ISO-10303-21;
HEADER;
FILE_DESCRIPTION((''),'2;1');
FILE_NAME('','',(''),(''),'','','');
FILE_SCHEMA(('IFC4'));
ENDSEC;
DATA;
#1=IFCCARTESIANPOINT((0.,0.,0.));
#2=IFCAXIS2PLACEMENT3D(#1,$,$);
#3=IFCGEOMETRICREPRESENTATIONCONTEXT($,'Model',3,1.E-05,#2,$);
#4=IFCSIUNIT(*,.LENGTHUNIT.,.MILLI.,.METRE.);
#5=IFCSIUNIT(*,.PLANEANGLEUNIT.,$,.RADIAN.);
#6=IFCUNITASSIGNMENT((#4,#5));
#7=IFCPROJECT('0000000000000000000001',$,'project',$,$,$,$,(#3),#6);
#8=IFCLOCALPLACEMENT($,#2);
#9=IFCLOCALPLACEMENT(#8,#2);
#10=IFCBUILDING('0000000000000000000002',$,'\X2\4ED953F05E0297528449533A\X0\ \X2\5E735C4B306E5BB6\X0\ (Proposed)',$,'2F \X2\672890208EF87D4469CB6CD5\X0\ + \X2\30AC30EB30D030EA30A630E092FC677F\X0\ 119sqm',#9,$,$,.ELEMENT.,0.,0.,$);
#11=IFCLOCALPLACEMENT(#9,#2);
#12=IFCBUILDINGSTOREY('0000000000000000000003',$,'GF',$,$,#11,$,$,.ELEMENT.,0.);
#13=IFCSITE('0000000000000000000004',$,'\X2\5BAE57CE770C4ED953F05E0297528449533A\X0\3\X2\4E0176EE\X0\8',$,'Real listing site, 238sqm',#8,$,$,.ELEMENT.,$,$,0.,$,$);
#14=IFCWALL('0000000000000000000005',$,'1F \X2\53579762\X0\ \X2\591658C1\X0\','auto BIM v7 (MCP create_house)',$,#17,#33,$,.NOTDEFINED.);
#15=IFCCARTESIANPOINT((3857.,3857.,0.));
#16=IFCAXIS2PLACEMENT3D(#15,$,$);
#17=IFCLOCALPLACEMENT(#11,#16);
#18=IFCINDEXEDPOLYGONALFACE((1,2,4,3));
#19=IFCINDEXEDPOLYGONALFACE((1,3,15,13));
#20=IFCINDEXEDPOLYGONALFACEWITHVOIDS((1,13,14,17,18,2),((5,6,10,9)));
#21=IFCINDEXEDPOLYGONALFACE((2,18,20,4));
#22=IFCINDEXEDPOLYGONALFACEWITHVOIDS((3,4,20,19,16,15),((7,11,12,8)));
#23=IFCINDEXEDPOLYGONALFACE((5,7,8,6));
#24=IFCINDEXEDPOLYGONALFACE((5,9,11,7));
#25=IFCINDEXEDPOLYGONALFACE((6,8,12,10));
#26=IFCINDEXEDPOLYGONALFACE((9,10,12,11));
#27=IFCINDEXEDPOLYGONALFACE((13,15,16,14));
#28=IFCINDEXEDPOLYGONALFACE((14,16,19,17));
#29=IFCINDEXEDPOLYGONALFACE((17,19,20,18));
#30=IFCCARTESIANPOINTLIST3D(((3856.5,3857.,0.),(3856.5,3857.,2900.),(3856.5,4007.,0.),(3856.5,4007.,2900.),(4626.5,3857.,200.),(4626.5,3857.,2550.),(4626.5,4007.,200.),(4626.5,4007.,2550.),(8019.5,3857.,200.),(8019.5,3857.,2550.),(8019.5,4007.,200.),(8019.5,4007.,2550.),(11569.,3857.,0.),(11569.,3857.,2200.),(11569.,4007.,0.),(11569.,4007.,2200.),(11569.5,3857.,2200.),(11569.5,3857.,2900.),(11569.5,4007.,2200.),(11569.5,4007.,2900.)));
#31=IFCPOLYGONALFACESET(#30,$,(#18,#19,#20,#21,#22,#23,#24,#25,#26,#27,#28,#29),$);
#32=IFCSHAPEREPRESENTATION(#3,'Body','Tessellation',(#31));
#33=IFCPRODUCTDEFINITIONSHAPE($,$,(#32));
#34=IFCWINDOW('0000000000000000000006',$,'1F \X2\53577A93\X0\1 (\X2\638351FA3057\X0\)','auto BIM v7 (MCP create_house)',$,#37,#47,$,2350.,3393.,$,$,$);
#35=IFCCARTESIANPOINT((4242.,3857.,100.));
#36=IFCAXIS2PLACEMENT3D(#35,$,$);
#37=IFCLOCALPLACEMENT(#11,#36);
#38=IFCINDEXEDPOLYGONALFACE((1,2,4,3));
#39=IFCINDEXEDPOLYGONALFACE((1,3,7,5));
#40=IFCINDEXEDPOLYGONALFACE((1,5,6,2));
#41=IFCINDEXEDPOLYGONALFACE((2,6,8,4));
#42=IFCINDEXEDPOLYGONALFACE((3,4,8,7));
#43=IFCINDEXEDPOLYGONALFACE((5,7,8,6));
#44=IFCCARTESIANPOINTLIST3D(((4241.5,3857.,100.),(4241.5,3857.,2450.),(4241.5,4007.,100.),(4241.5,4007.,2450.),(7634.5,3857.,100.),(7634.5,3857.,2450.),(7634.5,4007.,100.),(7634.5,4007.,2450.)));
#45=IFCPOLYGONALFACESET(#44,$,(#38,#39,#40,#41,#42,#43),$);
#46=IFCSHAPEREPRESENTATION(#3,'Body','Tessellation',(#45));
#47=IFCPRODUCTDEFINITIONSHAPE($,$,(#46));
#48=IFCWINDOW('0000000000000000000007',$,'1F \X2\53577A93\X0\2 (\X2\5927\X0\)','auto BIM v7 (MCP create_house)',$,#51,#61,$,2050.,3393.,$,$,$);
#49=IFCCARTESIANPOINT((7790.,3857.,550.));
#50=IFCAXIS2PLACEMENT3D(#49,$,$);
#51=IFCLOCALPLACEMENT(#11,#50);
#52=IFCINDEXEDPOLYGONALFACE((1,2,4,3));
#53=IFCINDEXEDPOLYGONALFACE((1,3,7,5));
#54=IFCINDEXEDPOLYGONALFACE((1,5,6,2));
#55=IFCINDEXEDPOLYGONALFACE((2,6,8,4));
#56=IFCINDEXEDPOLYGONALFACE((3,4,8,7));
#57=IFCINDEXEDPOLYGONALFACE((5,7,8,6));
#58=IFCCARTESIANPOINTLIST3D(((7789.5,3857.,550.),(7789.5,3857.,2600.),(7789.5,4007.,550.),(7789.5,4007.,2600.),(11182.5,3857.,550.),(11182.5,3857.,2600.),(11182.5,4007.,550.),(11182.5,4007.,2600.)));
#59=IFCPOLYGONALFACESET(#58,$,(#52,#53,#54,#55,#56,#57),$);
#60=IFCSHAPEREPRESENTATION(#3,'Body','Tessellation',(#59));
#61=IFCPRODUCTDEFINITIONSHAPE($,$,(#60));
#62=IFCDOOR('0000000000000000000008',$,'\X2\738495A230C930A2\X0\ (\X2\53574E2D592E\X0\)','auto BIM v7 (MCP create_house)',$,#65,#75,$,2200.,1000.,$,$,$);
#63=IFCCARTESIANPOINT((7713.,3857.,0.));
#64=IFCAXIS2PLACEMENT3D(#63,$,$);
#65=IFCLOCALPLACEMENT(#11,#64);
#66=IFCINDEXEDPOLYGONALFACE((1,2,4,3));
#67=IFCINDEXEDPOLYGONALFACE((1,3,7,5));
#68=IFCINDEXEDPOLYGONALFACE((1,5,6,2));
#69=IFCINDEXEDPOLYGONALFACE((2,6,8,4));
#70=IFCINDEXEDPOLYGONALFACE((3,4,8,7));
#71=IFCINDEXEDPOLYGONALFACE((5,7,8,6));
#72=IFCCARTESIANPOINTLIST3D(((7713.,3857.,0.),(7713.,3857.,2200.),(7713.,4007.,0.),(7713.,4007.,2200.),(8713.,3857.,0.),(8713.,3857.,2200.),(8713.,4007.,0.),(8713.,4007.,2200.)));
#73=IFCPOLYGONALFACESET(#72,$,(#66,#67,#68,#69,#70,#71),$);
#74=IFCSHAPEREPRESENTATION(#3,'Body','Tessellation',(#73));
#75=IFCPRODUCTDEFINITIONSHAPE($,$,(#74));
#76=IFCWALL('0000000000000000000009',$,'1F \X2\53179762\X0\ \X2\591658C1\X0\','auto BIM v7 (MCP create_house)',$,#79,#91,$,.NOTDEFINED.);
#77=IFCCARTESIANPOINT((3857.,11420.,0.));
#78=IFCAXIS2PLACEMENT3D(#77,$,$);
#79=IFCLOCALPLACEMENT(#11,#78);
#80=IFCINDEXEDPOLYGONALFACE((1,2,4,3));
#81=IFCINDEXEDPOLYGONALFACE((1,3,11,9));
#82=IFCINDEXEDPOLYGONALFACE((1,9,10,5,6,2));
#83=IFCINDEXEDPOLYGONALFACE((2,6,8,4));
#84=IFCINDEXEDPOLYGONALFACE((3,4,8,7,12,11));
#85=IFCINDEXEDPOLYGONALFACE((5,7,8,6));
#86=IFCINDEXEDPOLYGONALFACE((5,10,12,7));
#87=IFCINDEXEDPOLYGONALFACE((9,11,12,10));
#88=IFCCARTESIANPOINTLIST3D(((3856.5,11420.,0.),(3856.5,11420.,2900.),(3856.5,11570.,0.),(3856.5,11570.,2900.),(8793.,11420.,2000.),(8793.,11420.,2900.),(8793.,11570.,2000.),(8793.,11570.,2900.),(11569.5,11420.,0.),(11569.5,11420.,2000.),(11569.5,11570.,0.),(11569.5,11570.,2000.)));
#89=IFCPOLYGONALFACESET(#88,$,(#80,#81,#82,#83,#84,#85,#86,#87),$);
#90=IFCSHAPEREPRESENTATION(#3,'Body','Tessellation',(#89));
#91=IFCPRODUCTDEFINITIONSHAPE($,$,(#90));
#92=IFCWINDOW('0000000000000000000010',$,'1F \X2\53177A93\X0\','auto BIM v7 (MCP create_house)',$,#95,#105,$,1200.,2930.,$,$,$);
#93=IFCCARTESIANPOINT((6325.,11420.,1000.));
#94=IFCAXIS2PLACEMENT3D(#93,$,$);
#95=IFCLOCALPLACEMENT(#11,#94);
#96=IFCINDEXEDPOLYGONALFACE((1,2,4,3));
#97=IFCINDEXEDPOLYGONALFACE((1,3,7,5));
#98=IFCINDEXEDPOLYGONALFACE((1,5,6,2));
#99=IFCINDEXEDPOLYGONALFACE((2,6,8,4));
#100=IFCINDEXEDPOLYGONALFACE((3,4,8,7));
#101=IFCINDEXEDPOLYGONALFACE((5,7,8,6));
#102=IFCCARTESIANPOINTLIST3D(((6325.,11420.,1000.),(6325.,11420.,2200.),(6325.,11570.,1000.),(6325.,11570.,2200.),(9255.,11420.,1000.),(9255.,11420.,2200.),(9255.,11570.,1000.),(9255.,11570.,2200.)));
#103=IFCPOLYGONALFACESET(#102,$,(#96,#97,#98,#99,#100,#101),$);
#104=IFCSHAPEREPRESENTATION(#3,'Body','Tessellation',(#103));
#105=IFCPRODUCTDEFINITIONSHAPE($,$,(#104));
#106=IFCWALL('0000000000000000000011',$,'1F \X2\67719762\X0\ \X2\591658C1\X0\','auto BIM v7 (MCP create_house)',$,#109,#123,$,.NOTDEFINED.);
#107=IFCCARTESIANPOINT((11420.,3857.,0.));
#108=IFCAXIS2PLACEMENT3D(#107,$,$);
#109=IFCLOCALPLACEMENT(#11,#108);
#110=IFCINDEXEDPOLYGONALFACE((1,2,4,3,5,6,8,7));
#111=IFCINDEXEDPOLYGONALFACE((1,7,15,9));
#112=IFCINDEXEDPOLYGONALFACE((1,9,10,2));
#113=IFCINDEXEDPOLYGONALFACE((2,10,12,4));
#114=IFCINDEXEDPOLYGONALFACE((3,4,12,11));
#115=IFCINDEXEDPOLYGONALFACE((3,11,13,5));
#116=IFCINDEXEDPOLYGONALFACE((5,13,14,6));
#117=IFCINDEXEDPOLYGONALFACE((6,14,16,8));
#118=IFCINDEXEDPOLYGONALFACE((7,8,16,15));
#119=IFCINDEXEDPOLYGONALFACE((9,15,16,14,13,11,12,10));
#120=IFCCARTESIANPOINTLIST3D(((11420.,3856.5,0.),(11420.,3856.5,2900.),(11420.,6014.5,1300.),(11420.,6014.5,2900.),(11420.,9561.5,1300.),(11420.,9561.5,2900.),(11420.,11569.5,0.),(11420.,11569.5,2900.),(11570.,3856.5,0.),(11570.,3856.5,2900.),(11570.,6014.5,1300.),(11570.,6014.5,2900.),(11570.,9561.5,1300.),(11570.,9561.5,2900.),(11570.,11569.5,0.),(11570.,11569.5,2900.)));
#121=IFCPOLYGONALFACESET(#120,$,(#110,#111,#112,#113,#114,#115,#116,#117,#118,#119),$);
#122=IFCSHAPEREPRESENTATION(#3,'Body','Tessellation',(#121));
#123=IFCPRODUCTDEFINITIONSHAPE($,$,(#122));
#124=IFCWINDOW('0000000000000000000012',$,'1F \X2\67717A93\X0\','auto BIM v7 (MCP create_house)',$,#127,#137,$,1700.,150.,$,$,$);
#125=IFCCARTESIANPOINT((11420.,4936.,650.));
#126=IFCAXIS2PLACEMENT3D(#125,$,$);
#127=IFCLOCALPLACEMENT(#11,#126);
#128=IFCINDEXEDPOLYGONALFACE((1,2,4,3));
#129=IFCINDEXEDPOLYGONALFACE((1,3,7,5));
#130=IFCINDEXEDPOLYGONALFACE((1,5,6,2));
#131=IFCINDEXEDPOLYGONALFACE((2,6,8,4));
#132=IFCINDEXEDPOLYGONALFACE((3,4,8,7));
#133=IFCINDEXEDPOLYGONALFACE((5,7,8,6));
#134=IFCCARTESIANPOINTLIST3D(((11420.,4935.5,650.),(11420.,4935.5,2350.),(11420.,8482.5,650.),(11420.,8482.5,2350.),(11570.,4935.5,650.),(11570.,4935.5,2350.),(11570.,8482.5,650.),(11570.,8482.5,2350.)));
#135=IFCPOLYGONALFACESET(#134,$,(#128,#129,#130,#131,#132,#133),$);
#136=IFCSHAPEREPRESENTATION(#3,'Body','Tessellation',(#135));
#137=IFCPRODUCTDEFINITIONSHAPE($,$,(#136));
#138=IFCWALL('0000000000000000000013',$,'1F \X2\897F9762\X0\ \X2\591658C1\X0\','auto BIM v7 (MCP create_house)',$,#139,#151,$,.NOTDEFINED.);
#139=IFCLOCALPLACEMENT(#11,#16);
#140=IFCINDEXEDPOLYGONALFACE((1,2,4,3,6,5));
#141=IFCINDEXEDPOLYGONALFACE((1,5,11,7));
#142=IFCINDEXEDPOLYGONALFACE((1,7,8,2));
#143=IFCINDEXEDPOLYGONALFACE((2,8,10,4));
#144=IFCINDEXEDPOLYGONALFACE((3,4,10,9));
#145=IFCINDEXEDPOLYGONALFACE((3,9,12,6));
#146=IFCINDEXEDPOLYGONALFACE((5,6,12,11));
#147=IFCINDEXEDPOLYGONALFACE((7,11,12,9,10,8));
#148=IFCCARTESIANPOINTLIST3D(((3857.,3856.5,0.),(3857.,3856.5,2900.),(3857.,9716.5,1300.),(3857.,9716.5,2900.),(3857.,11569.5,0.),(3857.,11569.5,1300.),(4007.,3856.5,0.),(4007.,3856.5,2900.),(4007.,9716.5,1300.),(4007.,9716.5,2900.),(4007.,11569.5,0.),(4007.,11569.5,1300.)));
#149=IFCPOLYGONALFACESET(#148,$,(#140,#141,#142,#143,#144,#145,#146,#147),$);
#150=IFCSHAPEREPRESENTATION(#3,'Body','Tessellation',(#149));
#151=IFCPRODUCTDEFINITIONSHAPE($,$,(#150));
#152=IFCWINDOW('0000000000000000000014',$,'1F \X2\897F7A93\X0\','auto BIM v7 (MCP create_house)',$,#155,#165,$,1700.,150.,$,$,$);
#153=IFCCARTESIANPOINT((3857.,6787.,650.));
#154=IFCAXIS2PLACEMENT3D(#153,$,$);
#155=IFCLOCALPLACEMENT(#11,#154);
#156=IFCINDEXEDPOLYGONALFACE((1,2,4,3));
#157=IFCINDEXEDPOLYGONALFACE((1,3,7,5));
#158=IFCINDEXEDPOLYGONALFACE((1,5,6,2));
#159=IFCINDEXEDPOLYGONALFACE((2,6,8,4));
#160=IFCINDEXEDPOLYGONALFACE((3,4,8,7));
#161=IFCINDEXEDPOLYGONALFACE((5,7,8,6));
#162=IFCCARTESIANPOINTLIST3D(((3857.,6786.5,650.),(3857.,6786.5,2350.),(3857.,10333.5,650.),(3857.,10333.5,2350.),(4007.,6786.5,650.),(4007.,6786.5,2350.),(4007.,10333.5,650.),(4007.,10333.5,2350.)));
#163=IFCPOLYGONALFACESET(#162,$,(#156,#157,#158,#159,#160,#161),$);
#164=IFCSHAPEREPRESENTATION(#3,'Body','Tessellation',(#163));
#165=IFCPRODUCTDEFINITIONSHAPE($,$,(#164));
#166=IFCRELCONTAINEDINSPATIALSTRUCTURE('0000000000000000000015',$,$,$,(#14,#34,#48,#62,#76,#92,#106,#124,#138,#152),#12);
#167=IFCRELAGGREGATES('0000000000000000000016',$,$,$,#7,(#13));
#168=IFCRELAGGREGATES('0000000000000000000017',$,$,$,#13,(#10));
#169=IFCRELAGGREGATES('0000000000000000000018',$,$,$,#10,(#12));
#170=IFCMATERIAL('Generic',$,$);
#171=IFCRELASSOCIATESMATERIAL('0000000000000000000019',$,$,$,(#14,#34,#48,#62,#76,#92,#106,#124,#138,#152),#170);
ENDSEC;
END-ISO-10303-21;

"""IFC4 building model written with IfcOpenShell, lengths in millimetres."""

from ifc_helpers import new_model, si_unit, frame, frame_2d, origin, place, context, project, spatial, rectangle, extrude, material, element, fill, save


model = new_model("IFC4")

# Units and contexts
model_context = context("Model", 3, precision=1e-05, world=origin())
ifc_project = project(units=[si_unit("LENGTHUNIT", "METRE", prefix="MILLI"), si_unit("PLANEANGLEUNIT", "RADIAN")], contexts=[model_context])

# Site, building, storey
site_placement = place(None, origin())
site = spatial("IfcSite", under=ifc_project, at=site_placement, Name="宮城県仙台市青葉区3丁目8", ObjectType="Real listing site, 238sqm", CompositionType="ELEMENT", RefElevation=0.0)
building_placement = place(site_placement, origin())
building = spatial("IfcBuilding", under=site, at=building_placement, Name="仙台市青葉区 平屋の家 (Proposed)", ObjectType="2F 木造軸組構法 + ガルバリウム鋼板 119sqm", CompositionType="ELEMENT", ElevationOfRefHeight=0.0, ElevationOfTerrain=0.0)
storey_placement = place(building_placement, origin())
storey = spatial("IfcBuildingStorey", under=building, at=storey_placement, Name="GF", CompositionType="ELEMENT", Elevation=0.0)

# Shared definitions
ifc_material = material(Name="Generic")

# Wall, openings, windows, door
wall_1_placement = place(storey_placement, frame((3857.0, 3857.0, 0.0)))
wall_1 = element("IfcWall", 1, at=wall_1_placement, inside=storey, material=ifc_material, Name="1F 南面 外壁", Description="auto BIM v7 (MCP create_house)", PredefinedType="NOTDEFINED", context=model_context, shape_type="SweptSolid", body=[
    extrude(rectangle(XDim=7713.0, YDim=150.0, at=frame_2d((3856.0, 75.0))), frame((3857.0, 3857.0, 0.0)), (0.0, 0.0, 1.0), 2900.0),
])
opening_1_placement = place(storey_placement, frame((4242.0, 3857.0, 100.0)))
opening_1 = element("IfcOpeningElement", 2, at=opening_1_placement, cuts=wall_1, PredefinedType="NOTDEFINED", context=model_context, shape_type="SweptSolid", body=[
    extrude(rectangle(XDim=3393.0, YDim=150.0, at=frame_2d((1696.0, 75.0))), frame((4242.0, 3857.0, 100.0)), (0.0, 0.0, 1.0), 2350.0),
])
opening_2_placement = place(storey_placement, frame((7790.0, 3857.0, 550.0)))
opening_2 = element("IfcOpeningElement", 3, at=opening_2_placement, cuts=wall_1, PredefinedType="NOTDEFINED", context=model_context, shape_type="SweptSolid", body=[
    extrude(rectangle(XDim=3393.0, YDim=150.0, at=frame_2d((1696.0, 75.0))), frame((7790.0, 3857.0, 550.0)), (0.0, 0.0, 1.0), 2050.0),
])
opening_3_placement = place(storey_placement, frame((7713.0, 3857.0, 0.0)))
opening_3 = element("IfcOpeningElement", 4, at=opening_3_placement, cuts=wall_1, PredefinedType="NOTDEFINED", context=model_context, shape_type="SweptSolid", body=[
    extrude(rectangle(XDim=1000.0, YDim=150.0, at=frame_2d((500.0, 75.0))), frame((7713.0, 3857.0, 0.0)), (0.0, 0.0, 1.0), 2200.0),
])
window_1_placement = place(storey_placement, frame((4242.0, 3857.0, 100.0)))
window_1 = element("IfcWindow", 5, at=window_1_placement, inside=storey, material=ifc_material, Name="1F 南窓1 (掃出し)", Description="auto BIM v7 (MCP create_house)", OverallHeight=2350.0, OverallWidth=3393.0, context=model_context, shape_type="SweptSolid", body=[
    extrude(rectangle(XDim=3393.0, YDim=150.0, at=frame_2d((1696.0, 75.0))), frame((4242.0, 3857.0, 100.0)), (0.0, 0.0, 1.0), 2350.0),
])
fill(opening_1, window_1)
window_2_placement = place(storey_placement, frame((7790.0, 3857.0, 550.0)))
window_2 = element("IfcWindow", 6, at=window_2_placement, inside=storey, material=ifc_material, Name="1F 南窓2 (大)", Description="auto BIM v7 (MCP create_house)", OverallHeight=2050.0, OverallWidth=3393.0, context=model_context, shape_type="SweptSolid", body=[
    extrude(rectangle(XDim=3393.0, YDim=150.0, at=frame_2d((1696.0, 75.0))), frame((7790.0, 3857.0, 550.0)), (0.0, 0.0, 1.0), 2050.0),
])
fill(opening_2, window_2)
door_placement = place(storey_placement, frame((7713.0, 3857.0, 0.0)))
door = element("IfcDoor", 7, at=door_placement, inside=storey, material=ifc_material, Name="玄関ドア (南中央)", Description="auto BIM v7 (MCP create_house)", OverallHeight=2200.0, OverallWidth=1000.0, context=model_context, shape_type="SweptSolid", body=[
    extrude(rectangle(XDim=1000.0, YDim=150.0, at=frame_2d((500.0, 75.0))), frame((7713.0, 3857.0, 0.0)), (0.0, 0.0, 1.0), 2200.0),
])
fill(opening_3, door)

# Walls, openings, windows
wall_2_placement = place(storey_placement, frame((3857.0, 11420.0, 0.0)))
wall_2 = element("IfcWall", 8, at=wall_2_placement, inside=storey, material=ifc_material, Name="1F 北面 外壁", Description="auto BIM v7 (MCP create_house)", PredefinedType="NOTDEFINED", context=model_context, shape_type="SweptSolid", body=[
    extrude(rectangle(XDim=7713.0, YDim=150.0, at=frame_2d((3856.0, 75.0))), frame((3857.0, 11420.0, 0.0)), (0.0, 0.0, 1.0), 2900.0),
])
opening_4_placement = place(storey_placement, frame((6325.0, 11420.0, 1000.0)))
opening_4 = element("IfcOpeningElement", 9, at=opening_4_placement, cuts=wall_2, PredefinedType="NOTDEFINED", context=model_context, shape_type="SweptSolid", body=[
    extrude(rectangle(XDim=2930.0, YDim=150.0, at=frame_2d((1465.0, 75.0))), frame((6325.0, 11420.0, 1000.0)), (0.0, 0.0, 1.0), 1200.0),
])
window_3_placement = place(storey_placement, frame((6325.0, 11420.0, 1000.0)))
window_3 = element("IfcWindow", 10, at=window_3_placement, inside=storey, material=ifc_material, Name="1F 北窓", Description="auto BIM v7 (MCP create_house)", OverallHeight=1200.0, OverallWidth=2930.0, context=model_context, shape_type="SweptSolid", body=[
    extrude(rectangle(XDim=2930.0, YDim=150.0, at=frame_2d((1465.0, 75.0))), frame((6325.0, 11420.0, 1000.0)), (0.0, 0.0, 1.0), 1200.0),
])
fill(opening_4, window_3)
wall_3_placement = place(storey_placement, frame((11420.0, 3857.0, 0.0)))
wall_3 = element("IfcWall", 11, at=wall_3_placement, inside=storey, material=ifc_material, Name="1F 東面 外壁", Description="auto BIM v7 (MCP create_house)", PredefinedType="NOTDEFINED", context=model_context, shape_type="SweptSolid", body=[
    extrude(rectangle(XDim=150.0, YDim=7713.0, at=frame_2d((75.0, 3856.0))), frame((11420.0, 3857.0, 0.0)), (0.0, 0.0, 1.0), 2900.0),
])
opening_5_placement = place(storey_placement, frame((11420.0, 4936.0, 650.0)))
opening_5 = element("IfcOpeningElement", 12, at=opening_5_placement, cuts=wall_3, PredefinedType="NOTDEFINED", context=model_context, shape_type="SweptSolid", body=[
    extrude(rectangle(XDim=150.0, YDim=3547.0, at=frame_2d((75.0, 1773.0))), frame((11420.0, 4936.0, 650.0)), (0.0, 0.0, 1.0), 1700.0),
])
window_4_placement = place(storey_placement, frame((11420.0, 4936.0, 650.0)))
window_4 = element("IfcWindow", 13, at=window_4_placement, inside=storey, material=ifc_material, Name="1F 東窓", Description="auto BIM v7 (MCP create_house)", OverallHeight=1700.0, OverallWidth=150.0, context=model_context, shape_type="SweptSolid", body=[
    extrude(rectangle(XDim=150.0, YDim=3547.0, at=frame_2d((75.0, 1773.0))), frame((11420.0, 4936.0, 650.0)), (0.0, 0.0, 1.0), 1700.0),
])
fill(opening_5, window_4)
wall_4_placement = place(storey_placement, frame((3857.0, 3857.0, 0.0)))
wall_4 = element("IfcWall", 14, at=wall_4_placement, inside=storey, material=ifc_material, Name="1F 西面 外壁", Description="auto BIM v7 (MCP create_house)", PredefinedType="NOTDEFINED", context=model_context, shape_type="SweptSolid", body=[
    extrude(rectangle(XDim=150.0, YDim=7713.0, at=frame_2d((75.0, 3856.0))), frame((3857.0, 3857.0, 0.0)), (0.0, 0.0, 1.0), 2900.0),
])
opening_6_placement = place(storey_placement, frame((3857.0, 6787.0, 650.0)))
opening_6 = element("IfcOpeningElement", 15, at=opening_6_placement, cuts=wall_4, PredefinedType="NOTDEFINED", context=model_context, shape_type="SweptSolid", body=[
    extrude(rectangle(XDim=150.0, YDim=3547.0, at=frame_2d((75.0, 1773.0))), frame((3857.0, 6787.0, 650.0)), (0.0, 0.0, 1.0), 1700.0),
])
window_5_placement = place(storey_placement, frame((3857.0, 6787.0, 650.0)))
window_5 = element("IfcWindow", 16, at=window_5_placement, inside=storey, material=ifc_material, Name="1F 西窓", Description="auto BIM v7 (MCP create_house)", OverallHeight=1700.0, OverallWidth=150.0, context=model_context, shape_type="SweptSolid", body=[
    extrude(rectangle(XDim=150.0, YDim=3547.0, at=frame_2d((75.0, 1773.0))), frame((3857.0, 6787.0, 650.0)), (0.0, 0.0, 1.0), 1700.0),
])
fill(opening_6, window_5)

save(model, "model.ifc")
